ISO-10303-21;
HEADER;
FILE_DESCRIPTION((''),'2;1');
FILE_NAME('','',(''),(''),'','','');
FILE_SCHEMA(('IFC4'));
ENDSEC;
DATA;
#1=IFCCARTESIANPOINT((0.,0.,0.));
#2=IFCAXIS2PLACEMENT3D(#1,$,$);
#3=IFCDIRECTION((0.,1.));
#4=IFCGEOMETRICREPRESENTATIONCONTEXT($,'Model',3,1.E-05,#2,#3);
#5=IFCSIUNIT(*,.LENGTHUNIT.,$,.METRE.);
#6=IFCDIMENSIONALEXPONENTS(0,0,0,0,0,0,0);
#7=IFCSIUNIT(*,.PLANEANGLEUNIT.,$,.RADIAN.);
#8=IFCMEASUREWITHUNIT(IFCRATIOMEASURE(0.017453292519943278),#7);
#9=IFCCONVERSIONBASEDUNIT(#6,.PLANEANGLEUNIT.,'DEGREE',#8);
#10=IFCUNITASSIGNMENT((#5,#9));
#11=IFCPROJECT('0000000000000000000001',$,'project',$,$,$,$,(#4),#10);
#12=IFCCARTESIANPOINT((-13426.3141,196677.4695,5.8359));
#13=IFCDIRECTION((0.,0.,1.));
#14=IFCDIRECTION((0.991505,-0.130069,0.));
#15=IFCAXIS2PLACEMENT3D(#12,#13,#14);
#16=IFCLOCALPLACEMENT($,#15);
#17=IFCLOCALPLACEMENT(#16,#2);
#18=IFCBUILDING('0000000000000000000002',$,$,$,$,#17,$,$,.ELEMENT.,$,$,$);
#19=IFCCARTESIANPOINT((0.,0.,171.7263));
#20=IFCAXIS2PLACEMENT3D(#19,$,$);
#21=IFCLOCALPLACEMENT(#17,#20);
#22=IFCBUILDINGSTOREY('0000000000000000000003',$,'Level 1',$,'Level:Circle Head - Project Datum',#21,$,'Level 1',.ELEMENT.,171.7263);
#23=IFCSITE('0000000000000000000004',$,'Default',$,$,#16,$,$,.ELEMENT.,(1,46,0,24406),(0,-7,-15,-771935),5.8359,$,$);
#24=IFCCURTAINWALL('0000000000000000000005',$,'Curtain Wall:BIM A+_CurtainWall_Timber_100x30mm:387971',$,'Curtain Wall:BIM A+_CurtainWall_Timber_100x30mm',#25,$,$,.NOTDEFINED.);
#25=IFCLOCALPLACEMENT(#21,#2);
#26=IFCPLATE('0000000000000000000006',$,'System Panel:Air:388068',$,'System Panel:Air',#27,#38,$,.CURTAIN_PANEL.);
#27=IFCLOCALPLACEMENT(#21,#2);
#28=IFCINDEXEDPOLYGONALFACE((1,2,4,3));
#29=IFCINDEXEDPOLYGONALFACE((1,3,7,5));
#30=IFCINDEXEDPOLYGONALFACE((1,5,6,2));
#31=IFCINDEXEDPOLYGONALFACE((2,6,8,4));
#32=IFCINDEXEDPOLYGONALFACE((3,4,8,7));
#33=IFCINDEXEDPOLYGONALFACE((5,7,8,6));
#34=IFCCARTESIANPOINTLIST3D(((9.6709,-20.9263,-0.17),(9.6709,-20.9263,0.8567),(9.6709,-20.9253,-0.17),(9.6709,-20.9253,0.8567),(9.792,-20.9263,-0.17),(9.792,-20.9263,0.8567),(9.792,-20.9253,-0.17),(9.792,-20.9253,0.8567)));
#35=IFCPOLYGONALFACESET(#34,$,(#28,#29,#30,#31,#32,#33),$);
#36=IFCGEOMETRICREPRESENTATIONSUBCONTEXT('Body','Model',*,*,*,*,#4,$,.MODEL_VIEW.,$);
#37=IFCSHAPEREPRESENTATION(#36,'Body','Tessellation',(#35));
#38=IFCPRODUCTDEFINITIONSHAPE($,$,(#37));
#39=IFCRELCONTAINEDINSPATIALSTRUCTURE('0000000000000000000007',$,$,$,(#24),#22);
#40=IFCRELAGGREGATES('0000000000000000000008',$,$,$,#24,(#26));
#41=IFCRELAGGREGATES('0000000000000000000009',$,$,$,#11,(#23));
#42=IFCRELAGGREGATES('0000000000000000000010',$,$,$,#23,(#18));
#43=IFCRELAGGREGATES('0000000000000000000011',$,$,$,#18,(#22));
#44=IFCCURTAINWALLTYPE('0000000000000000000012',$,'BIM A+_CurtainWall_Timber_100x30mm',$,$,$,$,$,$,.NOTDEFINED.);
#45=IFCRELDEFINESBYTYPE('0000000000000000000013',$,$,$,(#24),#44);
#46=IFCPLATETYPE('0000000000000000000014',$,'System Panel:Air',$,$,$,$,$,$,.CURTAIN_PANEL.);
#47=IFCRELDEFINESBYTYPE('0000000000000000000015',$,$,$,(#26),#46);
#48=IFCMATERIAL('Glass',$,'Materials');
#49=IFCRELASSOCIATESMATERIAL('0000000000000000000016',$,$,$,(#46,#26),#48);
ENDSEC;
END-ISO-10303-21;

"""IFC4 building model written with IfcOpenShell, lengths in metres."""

from ifc_helpers import new_model, entity, si_unit, converted_unit, direction, frame, origin, place, context, subcontext, project, spatial, indexed_curve, outline, extrude, source, transform, mapped, material, type_object, type_shapes, element, aggregate, save


model = new_model("IFC4")

# Units and contexts
model_context = context("Model", 3, precision=1e-05, world=origin(), true_north=direction((0.0, 1.0)))
body_context = subcontext(model_context, "Body", "Model", "MODEL_VIEW")
ifc_project = project(units=[si_unit("LENGTHUNIT", "METRE"), converted_unit("PLANEANGLEUNIT", "DEGREE", entity("IfcRatioMeasure", 0.017453292519943278), si_unit("PLANEANGLEUNIT", "RADIAN"), dimensions=[0, 0, 0, 0, 0, 0, 0])], contexts=[model_context])

# Site, building, storey
site_placement = place(None, frame((-13426.3141, 196677.4695, 5.8359), z_axis=(0.0, 0.0, 1.0), x_axis=(0.991505, -0.130069, 0.0)))
site = spatial("IfcSite", under=ifc_project, at=site_placement, Name="Default", CompositionType="ELEMENT", RefLatitude=(1, 46, 0, 24406), RefLongitude=(0, -7, -15, -771935), RefElevation=5.8359)
building_placement = place(site_placement, origin())
building = spatial("IfcBuilding", under=site, at=building_placement, CompositionType="ELEMENT")
storey_placement = place(building_placement, frame((0.0, 0.0, 171.7263)))
storey = spatial("IfcBuildingStorey", under=building, at=storey_placement, Name="Level 1", ObjectType="Level:Circle Head - Project Datum", LongName="Level 1", CompositionType="ELEMENT", Elevation=171.7263)

# Shared definitions
ifc_material_1 = material(Name="Glass", Category="Materials")

# Curtain wall, plate
curtain_wall_type_1 = type_object("IfcCurtainWallType", Name="BIM A+_CurtainWall_Timber_100x30mm", PredefinedType="NOTDEFINED")
curtain_wall_1_placement = place(storey_placement, frame((0.0, 0.0, -171.7263)))
curtain_wall_1 = element("IfcCurtainWall", 1, at=curtain_wall_1_placement, inside=storey, type_object=curtain_wall_type_1, Name="Curtain Wall:BIM A+_CurtainWall_Timber_100x30mm:387971", ObjectType="Curtain Wall:BIM A+_CurtainWall_Timber_100x30mm", PredefinedType="NOTDEFINED")
plate_type_1 = type_object("IfcPlateType", Name="System Panel:Air", PredefinedType="CURTAIN_PANEL", material=ifc_material_1)
shared_shape_1 = source(origin(), body_context, "Body", "SweptSolid", [
    extrude(outline(indexed_curve([(-0.0005, -0.0606), (0.0005, -0.0606), (0.0005, 0.0606), (-0.0005, 0.0606), (-0.0005, -0.0606)], self_intersect=False)), frame((0.0, 0.0, 0.0), z_axis=(0.0, 0.0, 1.0), x_axis=(0.0, 1.0, 0.0)), (0.0, 0.0, 1.0), 1.0267),
])
type_shapes(plate_type_1, [shared_shape_1])
plate_1_placement = place(curtain_wall_1_placement, frame((9.7315, -20.9258, 171.5563)))
plate_1 = element("IfcPlate", 2, at=plate_1_placement, type_object=plate_type_1, material=ifc_material_1, Name="System Panel:Air:388068", ObjectType="System Panel:Air", PredefinedType="CURTAIN_PANEL", context=body_context, shape_type="MappedRepresentation", body=[
    mapped(shared_shape_1, transform((0.0, 0.0, 0.0), scale=1.0)),
])
aggregate(curtain_wall_1, [plate_1])

save(model, "model.ifc")
